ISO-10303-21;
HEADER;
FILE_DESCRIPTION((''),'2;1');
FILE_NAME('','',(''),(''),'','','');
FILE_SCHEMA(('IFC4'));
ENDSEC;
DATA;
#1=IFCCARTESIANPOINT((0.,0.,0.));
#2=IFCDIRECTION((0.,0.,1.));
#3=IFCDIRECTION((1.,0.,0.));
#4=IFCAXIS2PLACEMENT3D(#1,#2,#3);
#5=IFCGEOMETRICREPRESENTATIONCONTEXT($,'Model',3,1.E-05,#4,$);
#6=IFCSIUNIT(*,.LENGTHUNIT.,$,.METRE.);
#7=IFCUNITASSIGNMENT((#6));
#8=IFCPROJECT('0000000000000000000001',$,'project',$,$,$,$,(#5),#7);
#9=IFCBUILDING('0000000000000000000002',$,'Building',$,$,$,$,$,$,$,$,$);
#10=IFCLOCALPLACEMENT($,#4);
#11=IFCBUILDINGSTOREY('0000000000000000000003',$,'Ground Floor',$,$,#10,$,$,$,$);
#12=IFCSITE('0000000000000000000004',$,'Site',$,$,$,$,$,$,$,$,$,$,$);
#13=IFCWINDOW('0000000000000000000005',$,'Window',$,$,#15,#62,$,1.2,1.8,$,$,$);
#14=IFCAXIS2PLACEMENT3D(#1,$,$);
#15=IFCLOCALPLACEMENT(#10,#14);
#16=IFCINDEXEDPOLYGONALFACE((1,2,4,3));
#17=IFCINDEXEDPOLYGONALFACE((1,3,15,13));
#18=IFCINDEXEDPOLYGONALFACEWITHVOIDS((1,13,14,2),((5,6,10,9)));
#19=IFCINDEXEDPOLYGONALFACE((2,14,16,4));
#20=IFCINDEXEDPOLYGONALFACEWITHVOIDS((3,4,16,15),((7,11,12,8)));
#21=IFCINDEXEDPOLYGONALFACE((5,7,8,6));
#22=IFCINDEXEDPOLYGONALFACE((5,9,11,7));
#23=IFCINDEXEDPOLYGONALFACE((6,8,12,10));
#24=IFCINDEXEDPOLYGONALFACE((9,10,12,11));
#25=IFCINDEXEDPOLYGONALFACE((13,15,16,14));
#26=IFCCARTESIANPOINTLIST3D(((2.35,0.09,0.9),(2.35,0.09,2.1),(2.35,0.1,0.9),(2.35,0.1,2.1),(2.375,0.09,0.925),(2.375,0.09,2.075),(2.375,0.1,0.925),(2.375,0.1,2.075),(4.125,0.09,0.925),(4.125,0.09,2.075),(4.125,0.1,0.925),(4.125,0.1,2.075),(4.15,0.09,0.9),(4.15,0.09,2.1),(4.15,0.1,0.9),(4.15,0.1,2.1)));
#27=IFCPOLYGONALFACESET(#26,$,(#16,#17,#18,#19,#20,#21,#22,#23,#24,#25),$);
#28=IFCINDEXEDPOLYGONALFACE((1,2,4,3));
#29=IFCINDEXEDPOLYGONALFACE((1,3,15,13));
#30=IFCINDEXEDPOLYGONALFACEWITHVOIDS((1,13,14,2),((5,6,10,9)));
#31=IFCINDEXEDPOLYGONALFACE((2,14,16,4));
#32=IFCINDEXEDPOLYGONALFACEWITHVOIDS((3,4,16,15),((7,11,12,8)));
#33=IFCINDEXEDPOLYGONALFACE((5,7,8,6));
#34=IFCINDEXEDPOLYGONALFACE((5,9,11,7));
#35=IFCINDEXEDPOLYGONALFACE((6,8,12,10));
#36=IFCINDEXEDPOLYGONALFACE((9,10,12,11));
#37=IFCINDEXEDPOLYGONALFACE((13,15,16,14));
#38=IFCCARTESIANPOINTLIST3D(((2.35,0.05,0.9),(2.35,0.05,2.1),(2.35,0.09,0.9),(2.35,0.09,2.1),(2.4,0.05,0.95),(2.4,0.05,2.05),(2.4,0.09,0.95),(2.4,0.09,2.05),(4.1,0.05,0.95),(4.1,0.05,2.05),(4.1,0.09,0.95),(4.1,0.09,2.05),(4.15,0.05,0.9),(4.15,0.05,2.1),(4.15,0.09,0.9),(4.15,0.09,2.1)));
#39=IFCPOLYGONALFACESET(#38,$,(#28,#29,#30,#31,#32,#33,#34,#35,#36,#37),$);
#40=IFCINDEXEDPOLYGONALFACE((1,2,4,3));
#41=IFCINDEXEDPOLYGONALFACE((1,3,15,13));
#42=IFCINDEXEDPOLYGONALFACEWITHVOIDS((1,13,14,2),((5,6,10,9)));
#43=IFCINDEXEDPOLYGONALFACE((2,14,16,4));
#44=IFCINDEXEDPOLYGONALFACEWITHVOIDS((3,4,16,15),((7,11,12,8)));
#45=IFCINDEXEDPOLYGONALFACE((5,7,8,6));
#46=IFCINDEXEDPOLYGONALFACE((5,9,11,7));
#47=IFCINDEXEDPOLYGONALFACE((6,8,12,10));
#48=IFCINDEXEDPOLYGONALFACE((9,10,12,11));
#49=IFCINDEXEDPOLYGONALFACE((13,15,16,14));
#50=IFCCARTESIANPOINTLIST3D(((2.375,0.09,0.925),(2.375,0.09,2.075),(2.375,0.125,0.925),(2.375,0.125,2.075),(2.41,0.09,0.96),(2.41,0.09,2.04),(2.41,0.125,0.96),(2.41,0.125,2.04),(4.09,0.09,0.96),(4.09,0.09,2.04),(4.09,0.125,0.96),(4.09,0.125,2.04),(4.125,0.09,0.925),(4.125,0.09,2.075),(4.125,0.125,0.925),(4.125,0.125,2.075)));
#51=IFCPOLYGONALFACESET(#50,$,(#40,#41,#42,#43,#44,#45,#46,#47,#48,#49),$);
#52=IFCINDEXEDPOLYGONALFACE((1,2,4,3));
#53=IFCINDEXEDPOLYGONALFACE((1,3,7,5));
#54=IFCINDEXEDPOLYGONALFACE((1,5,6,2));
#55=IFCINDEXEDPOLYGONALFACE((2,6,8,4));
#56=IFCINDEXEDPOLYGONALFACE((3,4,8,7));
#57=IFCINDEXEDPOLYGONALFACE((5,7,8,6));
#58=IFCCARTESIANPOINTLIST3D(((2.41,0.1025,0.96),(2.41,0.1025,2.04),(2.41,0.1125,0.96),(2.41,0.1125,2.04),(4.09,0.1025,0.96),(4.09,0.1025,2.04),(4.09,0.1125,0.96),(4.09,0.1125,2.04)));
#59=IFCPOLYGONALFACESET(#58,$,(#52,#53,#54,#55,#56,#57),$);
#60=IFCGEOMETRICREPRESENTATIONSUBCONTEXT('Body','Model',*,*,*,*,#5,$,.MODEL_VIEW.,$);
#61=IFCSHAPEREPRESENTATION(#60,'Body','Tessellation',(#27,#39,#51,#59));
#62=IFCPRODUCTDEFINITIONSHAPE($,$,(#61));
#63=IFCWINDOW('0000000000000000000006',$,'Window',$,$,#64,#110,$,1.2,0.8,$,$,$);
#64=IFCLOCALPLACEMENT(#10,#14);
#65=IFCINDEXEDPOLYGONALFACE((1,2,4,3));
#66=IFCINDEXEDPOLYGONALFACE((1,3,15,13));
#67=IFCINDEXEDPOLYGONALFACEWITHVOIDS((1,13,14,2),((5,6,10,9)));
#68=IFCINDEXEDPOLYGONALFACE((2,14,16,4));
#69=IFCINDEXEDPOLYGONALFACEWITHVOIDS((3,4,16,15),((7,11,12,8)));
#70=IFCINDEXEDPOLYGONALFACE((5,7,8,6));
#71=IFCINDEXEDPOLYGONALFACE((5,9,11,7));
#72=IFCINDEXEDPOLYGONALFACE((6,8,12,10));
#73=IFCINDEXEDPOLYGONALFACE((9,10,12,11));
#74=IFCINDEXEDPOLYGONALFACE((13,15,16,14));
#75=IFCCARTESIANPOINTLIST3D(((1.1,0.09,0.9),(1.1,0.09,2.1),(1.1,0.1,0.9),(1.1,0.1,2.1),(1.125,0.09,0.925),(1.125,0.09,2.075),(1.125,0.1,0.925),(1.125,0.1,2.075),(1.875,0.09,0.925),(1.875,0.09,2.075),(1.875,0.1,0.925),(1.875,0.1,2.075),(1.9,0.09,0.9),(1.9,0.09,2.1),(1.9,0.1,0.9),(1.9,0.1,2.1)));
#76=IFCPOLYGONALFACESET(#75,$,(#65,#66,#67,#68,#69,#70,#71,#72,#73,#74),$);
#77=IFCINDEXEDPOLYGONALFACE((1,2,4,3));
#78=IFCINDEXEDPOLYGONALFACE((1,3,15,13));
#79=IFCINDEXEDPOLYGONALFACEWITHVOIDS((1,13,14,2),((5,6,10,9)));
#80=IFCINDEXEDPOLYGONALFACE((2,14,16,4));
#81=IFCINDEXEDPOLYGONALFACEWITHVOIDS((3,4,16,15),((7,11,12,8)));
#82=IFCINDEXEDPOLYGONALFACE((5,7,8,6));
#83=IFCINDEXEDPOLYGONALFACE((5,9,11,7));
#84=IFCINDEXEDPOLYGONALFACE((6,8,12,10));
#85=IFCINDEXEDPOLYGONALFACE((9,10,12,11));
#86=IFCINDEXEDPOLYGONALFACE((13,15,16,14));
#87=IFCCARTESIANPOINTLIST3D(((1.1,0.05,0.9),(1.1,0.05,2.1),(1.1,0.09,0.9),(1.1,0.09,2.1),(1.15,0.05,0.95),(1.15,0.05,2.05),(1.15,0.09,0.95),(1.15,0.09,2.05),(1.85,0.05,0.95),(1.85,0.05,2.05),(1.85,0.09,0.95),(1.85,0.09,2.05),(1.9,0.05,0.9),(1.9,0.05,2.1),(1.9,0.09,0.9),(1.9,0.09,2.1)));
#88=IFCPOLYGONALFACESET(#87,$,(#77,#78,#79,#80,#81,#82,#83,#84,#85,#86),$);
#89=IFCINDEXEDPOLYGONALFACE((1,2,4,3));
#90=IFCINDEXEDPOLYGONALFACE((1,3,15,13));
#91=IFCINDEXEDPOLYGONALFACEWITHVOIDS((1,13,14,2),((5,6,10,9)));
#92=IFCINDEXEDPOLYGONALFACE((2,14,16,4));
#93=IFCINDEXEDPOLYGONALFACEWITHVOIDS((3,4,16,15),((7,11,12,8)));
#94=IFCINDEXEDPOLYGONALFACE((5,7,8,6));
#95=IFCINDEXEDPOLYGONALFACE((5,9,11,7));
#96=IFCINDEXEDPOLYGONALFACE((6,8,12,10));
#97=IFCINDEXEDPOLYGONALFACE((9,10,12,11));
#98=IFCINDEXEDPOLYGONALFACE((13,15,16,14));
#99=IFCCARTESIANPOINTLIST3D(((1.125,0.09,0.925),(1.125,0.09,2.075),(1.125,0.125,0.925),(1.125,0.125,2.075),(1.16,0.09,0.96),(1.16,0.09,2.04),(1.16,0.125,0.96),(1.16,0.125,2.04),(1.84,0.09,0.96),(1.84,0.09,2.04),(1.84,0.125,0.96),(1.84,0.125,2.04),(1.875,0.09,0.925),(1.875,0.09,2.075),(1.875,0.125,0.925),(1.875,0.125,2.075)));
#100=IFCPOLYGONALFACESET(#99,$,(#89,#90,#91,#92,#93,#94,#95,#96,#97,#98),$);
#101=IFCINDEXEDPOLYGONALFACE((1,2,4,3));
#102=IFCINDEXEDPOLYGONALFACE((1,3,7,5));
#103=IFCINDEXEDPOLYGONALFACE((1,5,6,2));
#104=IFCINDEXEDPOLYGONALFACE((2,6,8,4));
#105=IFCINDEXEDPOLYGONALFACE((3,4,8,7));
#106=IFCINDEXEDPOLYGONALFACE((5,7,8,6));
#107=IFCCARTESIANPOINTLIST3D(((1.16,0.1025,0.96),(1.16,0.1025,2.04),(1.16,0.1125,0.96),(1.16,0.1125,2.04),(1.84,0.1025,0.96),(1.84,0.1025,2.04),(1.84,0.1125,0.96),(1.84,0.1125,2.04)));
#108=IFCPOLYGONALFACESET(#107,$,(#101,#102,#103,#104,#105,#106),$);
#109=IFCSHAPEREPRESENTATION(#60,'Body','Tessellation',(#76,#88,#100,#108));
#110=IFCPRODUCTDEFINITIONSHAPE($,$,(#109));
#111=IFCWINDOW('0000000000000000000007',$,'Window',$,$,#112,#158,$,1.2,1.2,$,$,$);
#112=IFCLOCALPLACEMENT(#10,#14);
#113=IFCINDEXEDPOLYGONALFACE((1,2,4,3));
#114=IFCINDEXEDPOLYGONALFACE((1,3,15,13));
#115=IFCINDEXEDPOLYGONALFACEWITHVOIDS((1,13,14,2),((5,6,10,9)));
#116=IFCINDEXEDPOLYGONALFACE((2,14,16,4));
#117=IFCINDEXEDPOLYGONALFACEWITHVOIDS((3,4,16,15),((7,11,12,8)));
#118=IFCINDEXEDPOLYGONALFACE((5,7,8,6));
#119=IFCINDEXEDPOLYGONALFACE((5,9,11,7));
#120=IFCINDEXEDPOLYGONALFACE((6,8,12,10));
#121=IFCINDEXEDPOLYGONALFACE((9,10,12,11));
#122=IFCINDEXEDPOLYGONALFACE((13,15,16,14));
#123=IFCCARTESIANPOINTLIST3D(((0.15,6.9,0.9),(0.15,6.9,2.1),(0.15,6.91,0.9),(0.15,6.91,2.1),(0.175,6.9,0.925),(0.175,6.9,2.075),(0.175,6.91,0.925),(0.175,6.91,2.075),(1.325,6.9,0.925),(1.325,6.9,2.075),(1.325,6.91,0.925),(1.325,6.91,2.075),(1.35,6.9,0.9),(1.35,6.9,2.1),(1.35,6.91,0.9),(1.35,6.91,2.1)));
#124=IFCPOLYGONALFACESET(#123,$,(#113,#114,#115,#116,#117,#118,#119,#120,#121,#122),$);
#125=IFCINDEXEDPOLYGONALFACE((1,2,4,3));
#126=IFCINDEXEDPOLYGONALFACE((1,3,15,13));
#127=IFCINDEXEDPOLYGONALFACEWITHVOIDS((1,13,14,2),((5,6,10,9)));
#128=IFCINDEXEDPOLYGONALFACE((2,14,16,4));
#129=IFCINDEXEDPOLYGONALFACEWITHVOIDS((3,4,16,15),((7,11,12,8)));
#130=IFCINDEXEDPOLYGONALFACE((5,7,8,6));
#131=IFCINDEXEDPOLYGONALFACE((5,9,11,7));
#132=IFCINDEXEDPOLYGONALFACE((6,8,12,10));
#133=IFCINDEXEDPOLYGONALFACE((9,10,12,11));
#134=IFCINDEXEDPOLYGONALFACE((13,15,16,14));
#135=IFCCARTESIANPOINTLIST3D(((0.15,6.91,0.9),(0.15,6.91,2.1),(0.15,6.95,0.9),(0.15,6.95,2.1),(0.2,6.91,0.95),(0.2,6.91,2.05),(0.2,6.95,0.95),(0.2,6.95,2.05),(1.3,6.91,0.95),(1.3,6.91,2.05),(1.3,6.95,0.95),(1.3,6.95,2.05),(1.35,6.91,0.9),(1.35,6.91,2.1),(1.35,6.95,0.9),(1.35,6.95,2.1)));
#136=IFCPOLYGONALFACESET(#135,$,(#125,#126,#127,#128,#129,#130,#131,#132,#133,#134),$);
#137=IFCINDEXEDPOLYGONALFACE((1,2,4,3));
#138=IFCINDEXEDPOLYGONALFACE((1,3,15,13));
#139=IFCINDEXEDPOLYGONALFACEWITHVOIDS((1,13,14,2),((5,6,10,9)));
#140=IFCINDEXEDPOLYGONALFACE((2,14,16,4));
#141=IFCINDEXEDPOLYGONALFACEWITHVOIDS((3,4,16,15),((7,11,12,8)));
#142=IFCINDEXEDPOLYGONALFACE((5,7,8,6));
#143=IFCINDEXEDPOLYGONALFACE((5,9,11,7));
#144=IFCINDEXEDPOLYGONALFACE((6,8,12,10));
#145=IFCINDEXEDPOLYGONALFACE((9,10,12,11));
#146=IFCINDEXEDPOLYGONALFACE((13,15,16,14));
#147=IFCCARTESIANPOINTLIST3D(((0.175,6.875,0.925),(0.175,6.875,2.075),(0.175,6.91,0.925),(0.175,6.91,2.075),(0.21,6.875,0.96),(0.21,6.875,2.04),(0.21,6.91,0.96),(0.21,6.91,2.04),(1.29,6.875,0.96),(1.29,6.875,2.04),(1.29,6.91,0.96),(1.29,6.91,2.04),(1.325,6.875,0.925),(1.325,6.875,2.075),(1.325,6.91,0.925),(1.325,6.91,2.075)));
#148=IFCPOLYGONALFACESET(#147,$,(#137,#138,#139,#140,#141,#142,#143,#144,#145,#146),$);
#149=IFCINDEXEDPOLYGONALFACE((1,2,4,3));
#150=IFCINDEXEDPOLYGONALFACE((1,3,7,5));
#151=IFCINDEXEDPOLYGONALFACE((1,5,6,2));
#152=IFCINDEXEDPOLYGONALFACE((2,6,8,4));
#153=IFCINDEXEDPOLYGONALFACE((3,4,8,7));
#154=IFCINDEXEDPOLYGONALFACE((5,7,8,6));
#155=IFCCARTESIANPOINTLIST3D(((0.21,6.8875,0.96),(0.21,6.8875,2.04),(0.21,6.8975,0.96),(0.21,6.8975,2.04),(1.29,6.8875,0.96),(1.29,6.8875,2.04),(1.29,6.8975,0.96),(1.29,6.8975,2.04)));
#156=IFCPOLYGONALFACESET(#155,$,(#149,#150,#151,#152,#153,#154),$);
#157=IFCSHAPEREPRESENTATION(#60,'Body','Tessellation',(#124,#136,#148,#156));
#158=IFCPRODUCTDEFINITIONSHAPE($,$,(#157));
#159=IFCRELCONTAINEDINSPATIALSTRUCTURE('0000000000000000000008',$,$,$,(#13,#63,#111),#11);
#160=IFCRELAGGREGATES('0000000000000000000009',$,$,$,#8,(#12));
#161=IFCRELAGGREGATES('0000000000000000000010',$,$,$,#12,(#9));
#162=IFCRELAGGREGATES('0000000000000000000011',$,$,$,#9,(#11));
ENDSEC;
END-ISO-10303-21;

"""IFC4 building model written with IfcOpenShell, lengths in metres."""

from ifc_helpers import new_model, si_unit, frame, origin_with_axes, place, context, subcontext, project, spatial, line, indexed_curve, outline, extrude, element, save


model = new_model("IFC4")

# Units and contexts
model_context = context("Model", 3, precision=1e-05, world=origin_with_axes())
body_context = subcontext(model_context, "Body", "Model", "MODEL_VIEW")
ifc_project = project(units=[si_unit("LENGTHUNIT", "METRE")], contexts=[model_context])

# Site, building, storey
site = spatial("IfcSite", under=ifc_project, Name="Site")
building = spatial("IfcBuilding", under=site, Name="Building")
storey_placement = place(None, origin_with_axes())
storey = spatial("IfcBuildingStorey", under=building, at=storey_placement, Name="Ground Floor")

# Windows
window_1_placement = place(storey_placement, frame((2.35, 0.0, 0.9), z_axis=(0.0, 0.0, 1.0), x_axis=(1.0, 0.0, 0.0)))
element("IfcWindow", 1, at=window_1_placement, inside=storey, Name="Window", OverallHeight=1.2, OverallWidth=1.8, context=body_context, shape_type="SweptSolid", body=[
    extrude(outline(indexed_curve([(0.0, 0.0), (1.8, 0.0), (1.8, 1.2), (0.0, 1.2)], segments=[line(1, 2, 3, 4, 1)]), holes=[indexed_curve([(0.025, 0.025), (1.775, 0.025), (1.775, 1.175), (0.025, 1.175)], segments=[line(1, 2, 3, 4, 1)])]), frame((0.0, 0.09, 0.0), z_axis=(0.0, -1.0, 0.0), x_axis=(1.0, 0.0, 0.0)), (0.0, 0.0, -1.0), 0.01),
    extrude(outline(indexed_curve([(0.0, 0.0), (1.8, 0.0), (1.8, 1.2), (0.0, 1.2)], segments=[line(1, 2, 3, 4, 1)]), holes=[indexed_curve([(0.05, 0.05), (1.75, 0.05), (1.75, 1.15), (0.05, 1.15)], segments=[line(1, 2, 3, 4, 1)])]), frame((0.0, 0.05, 0.0), z_axis=(0.0, -1.0, 0.0), x_axis=(1.0, 0.0, 0.0)), (0.0, 0.0, -1.0), 0.04),
    extrude(outline(indexed_curve([(0.0, 0.0), (1.75, 0.0), (1.75, 1.15), (0.0, 1.15)], segments=[line(1, 2, 3, 4, 1)]), holes=[indexed_curve([(0.035, 0.035), (1.715, 0.035), (1.715, 1.115), (0.035, 1.115)], segments=[line(1, 2, 3, 4, 1)])]), frame((0.025, 0.09, 0.025), z_axis=(0.0, -1.0, 0.0), x_axis=(1.0, 0.0, 0.0)), (0.0, 0.0, -1.0), 0.035),
    extrude(outline(indexed_curve([(0.035, 0.035), (1.715, 0.035), (1.715, 1.115), (0.035, 1.115)], segments=[line(1, 2, 3, 4, 1)])), frame((0.025, 0.1025, 0.025), z_axis=(0.0, -1.0, 0.0), x_axis=(1.0, 0.0, 0.0)), (0.0, 0.0, -1.0), 0.01),
])
window_2_placement = place(storey_placement, frame((1.1, 0.0, 0.9), z_axis=(0.0, 0.0, 1.0), x_axis=(1.0, 0.0, 0.0)))
element("IfcWindow", 2, at=window_2_placement, inside=storey, Name="Window", OverallHeight=1.2, OverallWidth=0.8, context=body_context, shape_type="SweptSolid", body=[
    extrude(outline(indexed_curve([(0.0, 0.0), (0.8, 0.0), (0.8, 1.2), (0.0, 1.2)], segments=[line(1, 2, 3, 4, 1)]), holes=[indexed_curve([(0.025, 0.025), (0.775, 0.025), (0.775, 1.175), (0.025, 1.175)], segments=[line(1, 2, 3, 4, 1)])]), frame((0.0, 0.09, 0.0), z_axis=(0.0, -1.0, 0.0), x_axis=(1.0, 0.0, 0.0)), (0.0, 0.0, -1.0), 0.01),
    extrude(outline(indexed_curve([(0.0, 0.0), (0.8, 0.0), (0.8, 1.2), (0.0, 1.2)], segments=[line(1, 2, 3, 4, 1)]), holes=[indexed_curve([(0.05, 0.05), (0.75, 0.05), (0.75, 1.15), (0.05, 1.15)], segments=[line(1, 2, 3, 4, 1)])]), frame((0.0, 0.05, 0.0), z_axis=(0.0, -1.0, 0.0), x_axis=(1.0, 0.0, 0.0)), (0.0, 0.0, -1.0), 0.04),
    extrude(outline(indexed_curve([(0.0, 0.0), (0.75, 0.0), (0.75, 1.15), (0.0, 1.15)], segments=[line(1, 2, 3, 4, 1)]), holes=[indexed_curve([(0.035, 0.035), (0.715, 0.035), (0.715, 1.115), (0.035, 1.115)], segments=[line(1, 2, 3, 4, 1)])]), frame((0.025, 0.09, 0.025), z_axis=(0.0, -1.0, 0.0), x_axis=(1.0, 0.0, 0.0)), (0.0, 0.0, -1.0), 0.035),
    extrude(outline(indexed_curve([(0.035, 0.035), (0.715, 0.035), (0.715, 1.115), (0.035, 1.115)], segments=[line(1, 2, 3, 4, 1)])), frame((0.025, 0.1025, 0.025), z_axis=(0.0, -1.0, 0.0), x_axis=(1.0, 0.0, 0.0)), (0.0, 0.0, -1.0), 0.01),
])
window_3_placement = place(storey_placement, frame((1.35, 7.0, 0.9), z_axis=(0.0, 0.0, 1.0), x_axis=(-1.0, 0.0, 0.0)))
element("IfcWindow", 3, at=window_3_placement, inside=storey, Name="Window", OverallHeight=1.2, OverallWidth=1.2, context=body_context, shape_type="SweptSolid", body=[
    extrude(outline(indexed_curve([(0.0, 0.0), (1.2, 0.0), (1.2, 1.2), (0.0, 1.2)], segments=[line(1, 2, 3, 4, 1)]), holes=[indexed_curve([(0.025, 0.025), (1.175, 0.025), (1.175, 1.175), (0.025, 1.175)], segments=[line(1, 2, 3, 4, 1)])]), frame((0.0, 0.09, 0.0), z_axis=(0.0, -1.0, 0.0), x_axis=(1.0, 0.0, 0.0)), (0.0, 0.0, -1.0), 0.01),
    extrude(outline(indexed_curve([(0.0, 0.0), (1.2, 0.0), (1.2, 1.2), (0.0, 1.2)], segments=[line(1, 2, 3, 4, 1)]), holes=[indexed_curve([(0.05, 0.05), (1.15, 0.05), (1.15, 1.15), (0.05, 1.15)], segments=[line(1, 2, 3, 4, 1)])]), frame((0.0, 0.05, 0.0), z_axis=(0.0, -1.0, 0.0), x_axis=(1.0, 0.0, 0.0)), (0.0, 0.0, -1.0), 0.04),
    extrude(outline(indexed_curve([(0.0, 0.0), (1.15, 0.0), (1.15, 1.15), (0.0, 1.15)], segments=[line(1, 2, 3, 4, 1)]), holes=[indexed_curve([(0.035, 0.035), (1.115, 0.035), (1.115, 1.115), (0.035, 1.115)], segments=[line(1, 2, 3, 4, 1)])]), frame((0.025, 0.09, 0.025), z_axis=(0.0, -1.0, 0.0), x_axis=(1.0, 0.0, 0.0)), (0.0, 0.0, -1.0), 0.035),
    extrude(outline(indexed_curve([(0.035, 0.035), (1.115, 0.035), (1.115, 1.115), (0.035, 1.115)], segments=[line(1, 2, 3, 4, 1)])), frame((0.025, 0.1025, 0.025), z_axis=(0.0, -1.0, 0.0), x_axis=(1.0, 0.0, 0.0)), (0.0, 0.0, -1.0), 0.01),
])

save(model, "model.ifc")
